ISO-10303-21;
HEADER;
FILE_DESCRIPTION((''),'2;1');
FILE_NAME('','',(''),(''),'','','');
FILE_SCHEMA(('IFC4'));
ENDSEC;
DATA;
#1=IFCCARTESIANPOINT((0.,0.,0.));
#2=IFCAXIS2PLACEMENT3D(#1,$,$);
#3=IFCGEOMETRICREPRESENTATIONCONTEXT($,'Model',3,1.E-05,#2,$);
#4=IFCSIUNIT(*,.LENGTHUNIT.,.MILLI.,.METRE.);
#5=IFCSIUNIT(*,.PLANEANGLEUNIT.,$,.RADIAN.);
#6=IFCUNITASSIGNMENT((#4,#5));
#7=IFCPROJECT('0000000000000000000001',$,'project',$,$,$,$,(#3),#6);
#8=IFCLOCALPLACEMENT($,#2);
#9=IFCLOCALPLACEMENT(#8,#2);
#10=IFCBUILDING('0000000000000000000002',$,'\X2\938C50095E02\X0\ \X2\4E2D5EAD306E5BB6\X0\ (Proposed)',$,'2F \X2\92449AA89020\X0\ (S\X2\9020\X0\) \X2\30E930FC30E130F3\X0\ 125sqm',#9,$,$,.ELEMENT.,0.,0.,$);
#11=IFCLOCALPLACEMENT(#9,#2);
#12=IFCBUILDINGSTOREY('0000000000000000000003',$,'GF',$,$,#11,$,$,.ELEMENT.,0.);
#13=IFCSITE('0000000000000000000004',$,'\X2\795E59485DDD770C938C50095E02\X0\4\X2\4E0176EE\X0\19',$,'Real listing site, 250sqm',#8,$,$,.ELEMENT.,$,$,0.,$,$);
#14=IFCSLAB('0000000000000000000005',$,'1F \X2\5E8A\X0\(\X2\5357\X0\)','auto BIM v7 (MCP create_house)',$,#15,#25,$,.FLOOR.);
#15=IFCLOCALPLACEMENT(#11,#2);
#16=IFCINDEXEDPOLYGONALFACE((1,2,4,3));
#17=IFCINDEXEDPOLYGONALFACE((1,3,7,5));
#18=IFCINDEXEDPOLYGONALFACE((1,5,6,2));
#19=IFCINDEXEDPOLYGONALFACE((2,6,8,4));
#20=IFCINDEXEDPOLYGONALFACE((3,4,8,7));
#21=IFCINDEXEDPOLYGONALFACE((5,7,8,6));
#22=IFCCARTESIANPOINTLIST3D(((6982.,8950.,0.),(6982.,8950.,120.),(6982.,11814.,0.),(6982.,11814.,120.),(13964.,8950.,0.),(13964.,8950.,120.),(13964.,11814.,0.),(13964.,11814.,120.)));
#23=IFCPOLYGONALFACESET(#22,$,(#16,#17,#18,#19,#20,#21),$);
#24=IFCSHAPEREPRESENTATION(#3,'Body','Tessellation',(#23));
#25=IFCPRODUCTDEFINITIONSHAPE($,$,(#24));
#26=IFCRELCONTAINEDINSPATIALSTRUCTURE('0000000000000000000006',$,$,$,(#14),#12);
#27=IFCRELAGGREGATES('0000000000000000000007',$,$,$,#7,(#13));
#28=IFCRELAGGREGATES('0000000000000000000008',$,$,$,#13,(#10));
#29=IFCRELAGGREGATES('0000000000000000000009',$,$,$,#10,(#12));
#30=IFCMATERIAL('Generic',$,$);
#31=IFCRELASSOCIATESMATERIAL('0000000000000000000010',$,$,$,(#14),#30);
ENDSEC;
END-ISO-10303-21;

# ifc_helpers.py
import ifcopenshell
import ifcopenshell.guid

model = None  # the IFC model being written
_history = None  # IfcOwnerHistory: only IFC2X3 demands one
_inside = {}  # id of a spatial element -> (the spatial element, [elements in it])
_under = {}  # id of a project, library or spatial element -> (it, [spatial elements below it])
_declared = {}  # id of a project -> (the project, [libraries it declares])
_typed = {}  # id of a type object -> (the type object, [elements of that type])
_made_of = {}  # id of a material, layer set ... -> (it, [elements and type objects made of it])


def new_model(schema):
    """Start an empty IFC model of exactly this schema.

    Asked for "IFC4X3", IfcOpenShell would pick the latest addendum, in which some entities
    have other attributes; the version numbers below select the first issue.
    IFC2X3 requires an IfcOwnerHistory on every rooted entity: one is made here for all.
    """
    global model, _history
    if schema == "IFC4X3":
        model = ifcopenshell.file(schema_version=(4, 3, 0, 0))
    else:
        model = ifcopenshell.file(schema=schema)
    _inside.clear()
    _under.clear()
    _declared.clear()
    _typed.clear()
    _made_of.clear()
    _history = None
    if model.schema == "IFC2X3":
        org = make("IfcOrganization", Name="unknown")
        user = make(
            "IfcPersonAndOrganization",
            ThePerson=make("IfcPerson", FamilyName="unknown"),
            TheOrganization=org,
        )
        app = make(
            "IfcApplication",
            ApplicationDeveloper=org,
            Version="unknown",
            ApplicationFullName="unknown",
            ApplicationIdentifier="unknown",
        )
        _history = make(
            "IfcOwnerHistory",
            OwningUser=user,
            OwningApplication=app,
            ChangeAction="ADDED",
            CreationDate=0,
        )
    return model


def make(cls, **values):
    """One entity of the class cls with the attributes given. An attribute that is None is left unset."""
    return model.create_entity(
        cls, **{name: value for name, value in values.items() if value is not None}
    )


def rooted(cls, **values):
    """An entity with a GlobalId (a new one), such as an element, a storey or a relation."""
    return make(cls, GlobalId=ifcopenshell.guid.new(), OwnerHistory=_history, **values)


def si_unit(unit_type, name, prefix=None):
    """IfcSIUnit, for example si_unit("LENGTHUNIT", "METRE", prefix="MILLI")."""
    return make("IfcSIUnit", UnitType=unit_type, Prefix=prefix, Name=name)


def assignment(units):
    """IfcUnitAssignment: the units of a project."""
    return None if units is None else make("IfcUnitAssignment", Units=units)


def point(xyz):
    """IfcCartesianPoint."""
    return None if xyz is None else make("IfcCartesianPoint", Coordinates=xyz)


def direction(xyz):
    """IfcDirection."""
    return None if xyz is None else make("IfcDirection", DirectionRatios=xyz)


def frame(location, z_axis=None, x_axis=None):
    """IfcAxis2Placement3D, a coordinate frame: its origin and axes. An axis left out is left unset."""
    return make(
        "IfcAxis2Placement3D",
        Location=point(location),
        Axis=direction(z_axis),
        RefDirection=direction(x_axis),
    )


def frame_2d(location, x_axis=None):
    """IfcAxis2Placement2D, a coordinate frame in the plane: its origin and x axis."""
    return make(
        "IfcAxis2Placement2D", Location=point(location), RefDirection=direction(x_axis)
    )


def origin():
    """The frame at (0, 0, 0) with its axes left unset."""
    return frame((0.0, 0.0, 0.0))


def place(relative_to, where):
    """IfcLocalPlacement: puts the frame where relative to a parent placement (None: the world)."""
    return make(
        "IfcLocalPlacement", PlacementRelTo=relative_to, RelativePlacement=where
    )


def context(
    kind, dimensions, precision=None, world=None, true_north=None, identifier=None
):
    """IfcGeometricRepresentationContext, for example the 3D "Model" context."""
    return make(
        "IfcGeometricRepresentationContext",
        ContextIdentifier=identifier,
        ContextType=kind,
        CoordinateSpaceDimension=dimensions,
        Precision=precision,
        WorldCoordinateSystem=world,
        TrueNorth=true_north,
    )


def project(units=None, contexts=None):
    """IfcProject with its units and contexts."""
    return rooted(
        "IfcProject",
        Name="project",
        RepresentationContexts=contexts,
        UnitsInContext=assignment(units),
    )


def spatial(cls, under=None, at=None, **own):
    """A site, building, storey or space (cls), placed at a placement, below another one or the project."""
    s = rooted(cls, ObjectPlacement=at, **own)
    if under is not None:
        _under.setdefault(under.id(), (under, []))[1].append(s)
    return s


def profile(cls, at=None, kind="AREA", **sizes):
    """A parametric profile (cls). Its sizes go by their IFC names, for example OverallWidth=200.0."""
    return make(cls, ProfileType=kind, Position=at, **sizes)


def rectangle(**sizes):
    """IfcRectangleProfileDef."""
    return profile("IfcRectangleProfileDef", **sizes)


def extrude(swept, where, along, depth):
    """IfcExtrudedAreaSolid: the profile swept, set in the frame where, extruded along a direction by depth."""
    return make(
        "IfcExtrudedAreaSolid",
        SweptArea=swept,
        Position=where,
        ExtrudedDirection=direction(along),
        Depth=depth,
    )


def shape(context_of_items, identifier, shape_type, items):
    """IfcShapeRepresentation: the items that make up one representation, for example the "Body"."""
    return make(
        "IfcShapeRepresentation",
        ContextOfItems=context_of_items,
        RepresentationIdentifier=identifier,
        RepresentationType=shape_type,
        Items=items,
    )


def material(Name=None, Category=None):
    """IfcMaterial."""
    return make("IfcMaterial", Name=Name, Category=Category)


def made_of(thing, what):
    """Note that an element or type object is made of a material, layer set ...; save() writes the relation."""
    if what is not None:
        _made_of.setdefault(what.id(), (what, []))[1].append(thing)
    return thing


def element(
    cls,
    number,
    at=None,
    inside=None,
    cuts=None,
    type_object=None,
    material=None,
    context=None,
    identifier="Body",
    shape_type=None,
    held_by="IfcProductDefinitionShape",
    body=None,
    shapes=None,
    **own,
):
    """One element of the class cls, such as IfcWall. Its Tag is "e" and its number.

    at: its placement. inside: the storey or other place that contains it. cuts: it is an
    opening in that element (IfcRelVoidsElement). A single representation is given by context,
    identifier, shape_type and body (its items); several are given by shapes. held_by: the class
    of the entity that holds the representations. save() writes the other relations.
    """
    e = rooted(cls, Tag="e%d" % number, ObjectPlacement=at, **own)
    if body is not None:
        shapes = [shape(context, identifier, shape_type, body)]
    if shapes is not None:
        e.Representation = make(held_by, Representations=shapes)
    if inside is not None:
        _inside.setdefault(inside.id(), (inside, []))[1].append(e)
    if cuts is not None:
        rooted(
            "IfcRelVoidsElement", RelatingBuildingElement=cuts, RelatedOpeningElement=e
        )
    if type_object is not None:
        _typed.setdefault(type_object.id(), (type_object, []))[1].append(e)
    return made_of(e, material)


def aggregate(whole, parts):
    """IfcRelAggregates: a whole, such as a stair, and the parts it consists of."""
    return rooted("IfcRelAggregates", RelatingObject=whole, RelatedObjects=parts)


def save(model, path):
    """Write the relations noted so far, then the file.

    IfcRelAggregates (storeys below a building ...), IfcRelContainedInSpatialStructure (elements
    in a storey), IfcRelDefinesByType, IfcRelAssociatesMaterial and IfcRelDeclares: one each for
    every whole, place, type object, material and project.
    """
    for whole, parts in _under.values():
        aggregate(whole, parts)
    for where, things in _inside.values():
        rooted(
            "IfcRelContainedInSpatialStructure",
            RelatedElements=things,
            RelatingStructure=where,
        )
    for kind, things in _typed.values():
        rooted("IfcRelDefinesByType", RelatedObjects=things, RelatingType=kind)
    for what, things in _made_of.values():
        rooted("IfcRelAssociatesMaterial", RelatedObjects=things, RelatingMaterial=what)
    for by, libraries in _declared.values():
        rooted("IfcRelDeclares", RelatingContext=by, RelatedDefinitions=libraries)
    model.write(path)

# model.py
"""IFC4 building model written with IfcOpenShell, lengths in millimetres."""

from ifc_helpers import new_model, si_unit, frame, frame_2d, origin, place, context, project, spatial, rectangle, extrude, material, element, save


model = new_model("IFC4")

# Units and contexts
model_context = context("Model", 3, precision=1e-05, world=origin())
ifc_project = project(units=[si_unit("LENGTHUNIT", "METRE", prefix="MILLI"), si_unit("PLANEANGLEUNIT", "RADIAN")], contexts=[model_context])

# Site, building, storey
site_placement = place(None, origin())
site = spatial("IfcSite", under=ifc_project, at=site_placement, Name="神奈川県鎌倉市4丁目19", ObjectType="Real listing site, 250sqm", CompositionType="ELEMENT", RefElevation=0.0)
building_placement = place(site_placement, origin())
building = spatial("IfcBuilding", under=site, at=building_placement, Name="鎌倉市 中庭の家 (Proposed)", ObjectType="2F 鉄骨造 (S造) ラーメン 125sqm", CompositionType="ELEMENT", ElevationOfRefHeight=0.0, ElevationOfTerrain=0.0)
storey_placement = place(building_placement, origin())
storey = spatial("IfcBuildingStorey", under=building, at=storey_placement, Name="GF", CompositionType="ELEMENT", Elevation=0.0)

# Slab
ifc_material = material(Name="Generic")
slab_1_placement = place(storey_placement, frame((3491.0, 4475.0, 0.0)))
element("IfcSlab", 1, at=slab_1_placement, inside=storey, material=ifc_material, Name="1F 床(南)", Description="auto BIM v7 (MCP create_house)", PredefinedType="FLOOR", context=model_context, shape_type="SweptSolid", body=[
    extrude(rectangle(XDim=6982.0, YDim=2864.0, at=frame_2d((3491.0, 1432.0))), frame((3491.0, 4475.0, 0.0)), (0.0, 0.0, 1.0), 120.0),
])

save(model, "model.ifc")
